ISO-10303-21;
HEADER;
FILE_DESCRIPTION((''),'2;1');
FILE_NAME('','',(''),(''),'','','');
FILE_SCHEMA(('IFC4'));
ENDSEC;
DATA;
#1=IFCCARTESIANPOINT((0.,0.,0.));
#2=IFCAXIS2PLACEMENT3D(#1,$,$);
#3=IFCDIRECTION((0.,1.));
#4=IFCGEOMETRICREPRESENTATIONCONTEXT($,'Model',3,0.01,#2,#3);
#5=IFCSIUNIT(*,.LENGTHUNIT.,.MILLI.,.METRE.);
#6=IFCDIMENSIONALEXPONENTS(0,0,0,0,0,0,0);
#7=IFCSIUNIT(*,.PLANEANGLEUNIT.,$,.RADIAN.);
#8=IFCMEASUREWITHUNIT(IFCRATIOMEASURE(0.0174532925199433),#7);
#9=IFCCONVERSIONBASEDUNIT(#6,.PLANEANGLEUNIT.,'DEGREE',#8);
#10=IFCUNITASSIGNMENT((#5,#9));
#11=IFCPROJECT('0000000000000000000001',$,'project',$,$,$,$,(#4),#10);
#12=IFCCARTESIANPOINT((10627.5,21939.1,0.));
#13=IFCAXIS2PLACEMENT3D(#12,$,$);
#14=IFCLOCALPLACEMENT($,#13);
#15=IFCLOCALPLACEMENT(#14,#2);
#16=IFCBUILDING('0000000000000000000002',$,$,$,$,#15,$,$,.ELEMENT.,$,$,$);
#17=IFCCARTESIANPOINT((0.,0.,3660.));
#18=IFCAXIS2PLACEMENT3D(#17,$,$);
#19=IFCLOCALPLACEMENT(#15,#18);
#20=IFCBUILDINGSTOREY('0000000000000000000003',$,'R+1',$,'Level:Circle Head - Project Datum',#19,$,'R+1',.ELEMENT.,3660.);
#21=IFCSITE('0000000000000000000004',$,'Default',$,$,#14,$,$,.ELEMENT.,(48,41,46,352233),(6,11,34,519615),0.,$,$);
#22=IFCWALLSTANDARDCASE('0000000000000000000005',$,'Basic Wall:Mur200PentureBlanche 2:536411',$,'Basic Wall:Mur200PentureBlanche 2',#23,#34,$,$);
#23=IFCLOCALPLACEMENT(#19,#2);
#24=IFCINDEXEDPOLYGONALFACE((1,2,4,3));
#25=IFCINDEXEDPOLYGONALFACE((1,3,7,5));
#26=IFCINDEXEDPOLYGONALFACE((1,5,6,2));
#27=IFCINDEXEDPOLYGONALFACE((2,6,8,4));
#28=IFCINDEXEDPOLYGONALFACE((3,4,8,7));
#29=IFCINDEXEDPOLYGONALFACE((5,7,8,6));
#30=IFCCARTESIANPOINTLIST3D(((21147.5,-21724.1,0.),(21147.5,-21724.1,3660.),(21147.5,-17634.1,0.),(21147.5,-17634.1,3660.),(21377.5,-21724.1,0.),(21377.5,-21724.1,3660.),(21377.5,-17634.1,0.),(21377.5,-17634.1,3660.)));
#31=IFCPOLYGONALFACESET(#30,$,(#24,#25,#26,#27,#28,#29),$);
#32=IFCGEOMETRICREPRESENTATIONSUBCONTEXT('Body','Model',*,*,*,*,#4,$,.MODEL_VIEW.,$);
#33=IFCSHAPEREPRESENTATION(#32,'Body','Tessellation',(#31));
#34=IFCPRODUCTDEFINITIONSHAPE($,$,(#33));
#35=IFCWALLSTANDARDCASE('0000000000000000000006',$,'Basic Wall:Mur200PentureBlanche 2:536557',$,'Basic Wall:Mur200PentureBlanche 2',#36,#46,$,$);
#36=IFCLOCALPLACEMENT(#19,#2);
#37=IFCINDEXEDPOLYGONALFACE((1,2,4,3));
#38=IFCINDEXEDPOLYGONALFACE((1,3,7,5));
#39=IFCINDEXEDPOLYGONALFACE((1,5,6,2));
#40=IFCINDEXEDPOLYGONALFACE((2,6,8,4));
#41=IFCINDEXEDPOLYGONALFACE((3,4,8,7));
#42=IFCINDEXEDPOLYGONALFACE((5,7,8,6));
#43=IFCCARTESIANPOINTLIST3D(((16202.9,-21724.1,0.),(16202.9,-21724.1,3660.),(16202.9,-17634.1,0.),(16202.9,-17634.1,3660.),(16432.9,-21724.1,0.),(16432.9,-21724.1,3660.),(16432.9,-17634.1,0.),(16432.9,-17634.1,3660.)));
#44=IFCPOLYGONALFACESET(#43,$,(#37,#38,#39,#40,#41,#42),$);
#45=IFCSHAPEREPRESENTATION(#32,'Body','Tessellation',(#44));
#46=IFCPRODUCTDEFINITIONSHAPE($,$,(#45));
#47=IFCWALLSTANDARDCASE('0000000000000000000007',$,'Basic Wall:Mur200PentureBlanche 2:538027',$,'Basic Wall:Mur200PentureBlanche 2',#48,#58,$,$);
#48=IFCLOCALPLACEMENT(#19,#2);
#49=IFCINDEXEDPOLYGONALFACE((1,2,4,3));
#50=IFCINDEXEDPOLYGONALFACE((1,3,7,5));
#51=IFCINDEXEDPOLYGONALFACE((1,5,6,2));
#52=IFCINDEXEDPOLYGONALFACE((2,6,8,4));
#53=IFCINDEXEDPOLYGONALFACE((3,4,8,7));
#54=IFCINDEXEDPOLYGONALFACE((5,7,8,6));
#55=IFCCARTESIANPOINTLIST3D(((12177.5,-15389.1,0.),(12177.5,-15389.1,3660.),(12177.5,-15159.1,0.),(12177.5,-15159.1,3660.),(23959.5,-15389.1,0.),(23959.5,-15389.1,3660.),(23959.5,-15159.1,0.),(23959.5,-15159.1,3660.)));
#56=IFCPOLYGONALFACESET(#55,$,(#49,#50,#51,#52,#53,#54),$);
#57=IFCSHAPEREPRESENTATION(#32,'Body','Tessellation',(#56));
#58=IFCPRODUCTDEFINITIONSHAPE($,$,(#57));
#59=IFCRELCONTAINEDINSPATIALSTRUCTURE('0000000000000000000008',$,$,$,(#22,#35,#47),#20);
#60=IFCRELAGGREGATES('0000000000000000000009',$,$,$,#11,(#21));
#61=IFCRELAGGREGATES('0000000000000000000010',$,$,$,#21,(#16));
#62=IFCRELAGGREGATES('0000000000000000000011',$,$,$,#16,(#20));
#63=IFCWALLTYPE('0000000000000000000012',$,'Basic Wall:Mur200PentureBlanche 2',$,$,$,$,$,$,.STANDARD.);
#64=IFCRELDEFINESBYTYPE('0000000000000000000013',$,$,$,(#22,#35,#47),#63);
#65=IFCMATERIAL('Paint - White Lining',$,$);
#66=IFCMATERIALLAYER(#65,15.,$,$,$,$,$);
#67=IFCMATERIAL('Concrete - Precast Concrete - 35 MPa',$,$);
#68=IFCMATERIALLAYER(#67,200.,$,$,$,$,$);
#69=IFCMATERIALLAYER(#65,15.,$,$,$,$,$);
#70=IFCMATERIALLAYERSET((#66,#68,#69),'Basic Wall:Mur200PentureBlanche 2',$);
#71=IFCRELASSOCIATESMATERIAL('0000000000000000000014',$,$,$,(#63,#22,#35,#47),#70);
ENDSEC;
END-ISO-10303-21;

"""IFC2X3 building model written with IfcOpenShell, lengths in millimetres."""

from ifc_helpers import new_model, entity, si_unit, converted_unit, direction, frame, frame_2d, origin, place, context, subcontext, project, spatial, rectangle, extrude, material, layer, layer_set, layer_usage, type_object, element, save


model = new_model("IFC2X3")

# Units and contexts
model_context = context("Model", 3, precision=0.01, world=origin(), true_north=direction((0.0, 1.0)))
body_context = subcontext(model_context, "Body", "Model", "MODEL_VIEW")
ifc_project = project(units=[si_unit("LENGTHUNIT", "METRE", prefix="MILLI"), converted_unit("PLANEANGLEUNIT", "DEGREE", entity("IfcRatioMeasure", 0.0174532925199433), si_unit("PLANEANGLEUNIT", "RADIAN"), dimensions=[0, 0, 0, 0, 0, 0, 0])], contexts=[model_context])

# Site, building, storey
site_placement = place(None, frame((10627.5, 21939.1, 0.0)))
site = spatial("IfcSite", under=ifc_project, at=site_placement, Name="Default", CompositionType="ELEMENT", RefLatitude=(48, 41, 46, 352233), RefLongitude=(6, 11, 34, 519615), RefElevation=0.0)
building_placement = place(site_placement, origin())
building = spatial("IfcBuilding", under=site, at=building_placement, CompositionType="ELEMENT")
storey_placement = place(building_placement, frame((0.0, 0.0, 3660.0)))
storey = spatial("IfcBuildingStorey", under=building, at=storey_placement, Name="R+1", ObjectType="Level:Circle Head - Project Datum", LongName="R+1", CompositionType="ELEMENT", Elevation=3660.0)

# Walls
ifc_material_1 = material(Name="Paint - White Lining")
ifc_material_2 = material(Name="Concrete - Precast Concrete - 35 MPa")
ifc_layer_1 = layer(ifc_material_1, 15.0)
ifc_layer_2 = layer(ifc_material_2, 200.0)
ifc_layer_3 = layer(ifc_material_1, 15.0)
ifc_layer_set_1 = layer_set([ifc_layer_1, ifc_layer_2, ifc_layer_3], Name="Basic Wall:Mur200PentureBlanche 2")
wall_type_1 = type_object("IfcWallType", Name="Basic Wall:Mur200PentureBlanche 2", PredefinedType="STANDARD", material=ifc_layer_set_1)
ifc_layer_usage_1 = layer_usage(ifc_layer_set_1, "AXIS2", "NEGATIVE", 115.0)
wall_1_placement = place(storey_placement, frame((21262.5, -17634.1, 0.0), z_axis=(0.0, 0.0, 1.0), x_axis=(0.0, -1.0, 0.0)))
element("IfcWallStandardCase", 1, at=wall_1_placement, inside=storey, type_object=wall_type_1, material=ifc_layer_usage_1, Name="Basic Wall:Mur200PentureBlanche 2:536411", ObjectType="Basic Wall:Mur200PentureBlanche 2", context=body_context, shape_type="SweptSolid", body=[
    extrude(rectangle(XDim=4090.0, YDim=230.0, at=frame_2d((2045.0, 0.0), x_axis=(-1.0, 0.0))), origin(), (0.0, 0.0, 1.0), 3660.0),
])
ifc_layer_usage_2 = layer_usage(ifc_layer_set_1, "AXIS2", "POSITIVE", -115.0)
wall_2_placement = place(storey_placement, frame((16317.9, -17634.1, 0.0), z_axis=(0.0, 0.0, 1.0), x_axis=(0.0, -1.0, 0.0)))
element("IfcWallStandardCase", 2, at=wall_2_placement, inside=storey, type_object=wall_type_1, material=ifc_layer_usage_2, Name="Basic Wall:Mur200PentureBlanche 2:536557", ObjectType="Basic Wall:Mur200PentureBlanche 2", context=body_context, shape_type="SweptSolid", body=[
    extrude(rectangle(XDim=4090.0, YDim=230.0, at=frame_2d((2045.0, 0.0), x_axis=(-1.0, 0.0))), origin(), (0.0, 0.0, 1.0), 3660.0),
])
ifc_layer_usage_3 = layer_usage(ifc_layer_set_1, "AXIS2", "POSITIVE", -115.0)
wall_3_placement = place(storey_placement, frame((12177.5, -15274.1, 0.0)))
element("IfcWallStandardCase", 3, at=wall_3_placement, inside=storey, type_object=wall_type_1, material=ifc_layer_usage_3, Name="Basic Wall:Mur200PentureBlanche 2:538027", ObjectType="Basic Wall:Mur200PentureBlanche 2", context=body_context, shape_type="SweptSolid", body=[
    extrude(rectangle(XDim=11782.0, YDim=230.0, at=frame_2d((5891.0, 0.0), x_axis=(-1.0, 0.0))), origin(), (0.0, 0.0, 1.0), 3660.0),
])

save(model, "model.ifc")
